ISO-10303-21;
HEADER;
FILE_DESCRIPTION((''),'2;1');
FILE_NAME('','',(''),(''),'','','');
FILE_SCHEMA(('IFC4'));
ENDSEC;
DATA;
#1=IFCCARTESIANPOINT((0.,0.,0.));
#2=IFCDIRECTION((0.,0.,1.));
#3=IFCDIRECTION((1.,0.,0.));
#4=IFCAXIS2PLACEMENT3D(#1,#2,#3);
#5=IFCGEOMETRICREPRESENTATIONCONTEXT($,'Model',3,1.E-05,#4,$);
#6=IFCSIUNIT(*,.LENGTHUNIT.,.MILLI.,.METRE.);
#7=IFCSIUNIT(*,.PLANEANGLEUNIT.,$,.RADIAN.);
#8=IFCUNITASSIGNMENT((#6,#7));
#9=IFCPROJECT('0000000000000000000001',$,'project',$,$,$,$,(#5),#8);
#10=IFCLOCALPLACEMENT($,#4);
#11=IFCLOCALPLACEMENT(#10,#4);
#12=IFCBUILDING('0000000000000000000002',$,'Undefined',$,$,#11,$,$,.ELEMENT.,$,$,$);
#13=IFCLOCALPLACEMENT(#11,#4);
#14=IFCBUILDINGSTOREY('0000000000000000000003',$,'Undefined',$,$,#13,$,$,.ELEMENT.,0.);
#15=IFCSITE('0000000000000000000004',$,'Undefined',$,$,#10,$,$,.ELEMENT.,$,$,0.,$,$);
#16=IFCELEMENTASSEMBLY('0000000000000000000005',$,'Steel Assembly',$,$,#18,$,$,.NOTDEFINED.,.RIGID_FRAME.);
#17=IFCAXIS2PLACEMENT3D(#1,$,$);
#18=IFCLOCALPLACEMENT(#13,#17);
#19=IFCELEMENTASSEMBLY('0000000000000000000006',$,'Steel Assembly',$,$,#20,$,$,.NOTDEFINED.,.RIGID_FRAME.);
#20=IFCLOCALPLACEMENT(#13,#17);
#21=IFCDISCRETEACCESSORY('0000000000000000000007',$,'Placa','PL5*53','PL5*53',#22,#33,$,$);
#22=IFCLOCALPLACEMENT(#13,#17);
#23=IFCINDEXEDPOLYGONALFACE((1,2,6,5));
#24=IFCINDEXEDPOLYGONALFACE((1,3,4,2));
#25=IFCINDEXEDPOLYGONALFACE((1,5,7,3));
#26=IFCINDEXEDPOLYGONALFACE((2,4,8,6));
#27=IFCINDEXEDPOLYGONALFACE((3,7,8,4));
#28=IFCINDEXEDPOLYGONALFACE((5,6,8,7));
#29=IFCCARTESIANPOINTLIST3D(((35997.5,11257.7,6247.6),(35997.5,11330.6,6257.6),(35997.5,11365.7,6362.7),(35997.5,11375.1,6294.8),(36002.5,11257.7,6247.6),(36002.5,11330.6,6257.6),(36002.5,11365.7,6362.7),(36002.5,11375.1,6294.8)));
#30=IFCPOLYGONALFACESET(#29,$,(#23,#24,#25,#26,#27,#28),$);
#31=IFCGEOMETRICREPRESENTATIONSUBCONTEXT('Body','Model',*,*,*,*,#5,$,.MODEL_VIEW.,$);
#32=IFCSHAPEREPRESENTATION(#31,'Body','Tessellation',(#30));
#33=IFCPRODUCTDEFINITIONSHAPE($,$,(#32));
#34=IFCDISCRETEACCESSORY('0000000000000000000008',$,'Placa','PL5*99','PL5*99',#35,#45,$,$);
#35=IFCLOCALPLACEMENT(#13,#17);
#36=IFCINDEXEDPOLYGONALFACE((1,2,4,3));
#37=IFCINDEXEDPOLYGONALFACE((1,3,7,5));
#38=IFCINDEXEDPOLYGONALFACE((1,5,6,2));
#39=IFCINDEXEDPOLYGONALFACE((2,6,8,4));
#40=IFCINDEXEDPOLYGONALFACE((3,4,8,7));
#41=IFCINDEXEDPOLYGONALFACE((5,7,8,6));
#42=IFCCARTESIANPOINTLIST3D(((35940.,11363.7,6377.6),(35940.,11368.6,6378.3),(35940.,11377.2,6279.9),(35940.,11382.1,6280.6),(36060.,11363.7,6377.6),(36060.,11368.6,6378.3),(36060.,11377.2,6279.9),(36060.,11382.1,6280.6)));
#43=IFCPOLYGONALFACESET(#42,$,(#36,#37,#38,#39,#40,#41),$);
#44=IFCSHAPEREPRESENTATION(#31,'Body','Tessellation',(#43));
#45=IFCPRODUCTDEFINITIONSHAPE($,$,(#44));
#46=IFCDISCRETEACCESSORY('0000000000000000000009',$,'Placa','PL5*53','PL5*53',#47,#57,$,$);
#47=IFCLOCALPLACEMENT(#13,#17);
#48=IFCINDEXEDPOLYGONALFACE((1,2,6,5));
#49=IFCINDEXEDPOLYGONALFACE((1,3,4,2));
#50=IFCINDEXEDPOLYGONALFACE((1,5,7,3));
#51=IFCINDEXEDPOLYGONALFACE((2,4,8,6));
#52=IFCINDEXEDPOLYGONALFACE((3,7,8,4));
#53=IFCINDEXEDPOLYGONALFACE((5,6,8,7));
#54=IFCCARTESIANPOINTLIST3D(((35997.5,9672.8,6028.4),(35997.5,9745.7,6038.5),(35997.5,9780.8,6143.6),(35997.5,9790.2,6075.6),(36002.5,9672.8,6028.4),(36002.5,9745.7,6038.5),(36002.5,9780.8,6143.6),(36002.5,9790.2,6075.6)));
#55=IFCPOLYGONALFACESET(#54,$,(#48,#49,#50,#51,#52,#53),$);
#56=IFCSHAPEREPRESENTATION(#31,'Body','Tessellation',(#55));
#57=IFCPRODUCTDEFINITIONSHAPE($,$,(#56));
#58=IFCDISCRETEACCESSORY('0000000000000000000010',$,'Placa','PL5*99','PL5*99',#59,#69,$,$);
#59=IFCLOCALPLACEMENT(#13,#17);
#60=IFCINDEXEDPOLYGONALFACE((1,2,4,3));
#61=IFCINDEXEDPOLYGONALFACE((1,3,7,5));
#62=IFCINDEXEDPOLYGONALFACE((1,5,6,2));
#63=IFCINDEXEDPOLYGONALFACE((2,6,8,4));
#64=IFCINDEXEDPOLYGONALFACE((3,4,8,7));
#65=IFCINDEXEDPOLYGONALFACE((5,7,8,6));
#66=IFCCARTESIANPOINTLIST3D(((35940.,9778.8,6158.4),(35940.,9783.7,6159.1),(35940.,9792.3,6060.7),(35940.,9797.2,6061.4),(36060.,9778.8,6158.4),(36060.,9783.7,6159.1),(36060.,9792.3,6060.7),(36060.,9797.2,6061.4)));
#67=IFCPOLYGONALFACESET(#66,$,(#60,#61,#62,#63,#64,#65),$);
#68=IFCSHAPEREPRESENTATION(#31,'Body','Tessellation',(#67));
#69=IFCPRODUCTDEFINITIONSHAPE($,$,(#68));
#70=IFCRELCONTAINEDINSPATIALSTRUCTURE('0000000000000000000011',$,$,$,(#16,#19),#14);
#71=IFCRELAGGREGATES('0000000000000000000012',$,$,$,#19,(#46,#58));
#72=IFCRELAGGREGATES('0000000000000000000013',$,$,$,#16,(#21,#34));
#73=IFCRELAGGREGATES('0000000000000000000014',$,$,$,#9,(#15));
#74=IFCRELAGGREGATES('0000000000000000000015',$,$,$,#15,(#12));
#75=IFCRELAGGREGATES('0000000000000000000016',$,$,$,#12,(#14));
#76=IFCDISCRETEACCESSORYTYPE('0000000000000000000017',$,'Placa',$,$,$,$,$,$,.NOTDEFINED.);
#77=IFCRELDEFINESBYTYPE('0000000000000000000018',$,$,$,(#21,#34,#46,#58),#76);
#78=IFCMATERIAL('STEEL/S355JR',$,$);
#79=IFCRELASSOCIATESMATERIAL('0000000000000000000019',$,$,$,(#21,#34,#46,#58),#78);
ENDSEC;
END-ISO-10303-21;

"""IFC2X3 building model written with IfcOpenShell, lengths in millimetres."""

from ifc_helpers import new_model, si_unit, frame, origin_with_axes, place, context, subcontext, project, spatial, polyline, outline, extrude, material, type_object, element, aggregate, save


model = new_model("IFC2X3")

# Units and contexts
model_context = context("Model", 3, precision=1e-05, world=origin_with_axes())
body_context = subcontext(model_context, "Body", "Model", "MODEL_VIEW")
ifc_project = project(units=[si_unit("LENGTHUNIT", "METRE", prefix="MILLI"), si_unit("PLANEANGLEUNIT", "RADIAN")], contexts=[model_context])

# Site, building, storey
site_placement = place(None, origin_with_axes())
site = spatial("IfcSite", under=ifc_project, at=site_placement, Name="Undefined", CompositionType="ELEMENT", RefElevation=0.0)
building_placement = place(site_placement, origin_with_axes())
building = spatial("IfcBuilding", under=site, at=building_placement, Name="Undefined", CompositionType="ELEMENT")
storey_placement = place(building_placement, origin_with_axes())
storey = spatial("IfcBuildingStorey", under=building, at=storey_placement, Name="Undefined", CompositionType="ELEMENT", Elevation=0.0)

# Shared definitions
ifc_material_1 = material(Name="STEEL/S355JR")

# Element assemblies
assembly_1_placement = place(storey_placement, origin_with_axes())
assembly_1 = element("IfcElementAssembly", 1, at=assembly_1_placement, inside=storey, Name="Steel Assembly", AssemblyPlace="NOTDEFINED", PredefinedType="RIGID_FRAME")
assembly_2_placement = place(storey_placement, origin_with_axes())
assembly_2 = element("IfcElementAssembly", 2, at=assembly_2_placement, inside=storey, Name="Steel Assembly", AssemblyPlace="NOTDEFINED", PredefinedType="RIGID_FRAME")

# Discrete accessories
discrete_accessory_type_1 = type_object("IfcDiscreteAccessoryType", Name="Placa")
discrete_accessory_1_placement = place(assembly_1_placement, frame((36000.0, 11365.7, 6362.7), z_axis=(1.0, 0.0, 0.0), x_axis=(0.0, -0.684057, -0.729429)))
discrete_accessory_1 = element("IfcDiscreteAccessory", 3, at=discrete_accessory_1_placement, type_object=discrete_accessory_type_1, material=ifc_material_1, Name="Placa", Description="PL5*53", ObjectType="PL5*53", context=body_context, shape_type="SweptSolid", body=[
    extrude(outline(polyline([(0.0, 0.0), (157.9, 0.0), (100.7, 46.3), (43.1, 53.3), (0.0, 0.0)])), frame((0.0, 0.0, -2.5), z_axis=(0.0, 0.0, 1.0), x_axis=(1.0, 0.0, 0.0)), (0.0, 0.0, 1.0), 5.0),
])
discrete_accessory_2_placement = place(assembly_1_placement, frame((35940.0, 11379.7, 6280.3), z_axis=(0.0, 0.990592, 0.136849), x_axis=(0.0, -0.136849, 0.990592)))
discrete_accessory_2 = element("IfcDiscreteAccessory", 4, at=discrete_accessory_2_placement, type_object=discrete_accessory_type_1, material=ifc_material_1, Name="Placa", Description="PL5*99", ObjectType="PL5*99", context=body_context, shape_type="SweptSolid", body=[
    extrude(outline(polyline([(0.0, 0.0), (98.6, 0.0), (98.6, 120.0), (0.0, 120.0), (0.0, 0.0)])), frame((0.0, 0.0, -2.5), z_axis=(0.0, 0.0, 1.0), x_axis=(1.0, 0.0, 0.0)), (0.0, 0.0, 1.0), 5.0),
])
discrete_accessory_3_placement = place(assembly_2_placement, frame((36000.0, 9780.8, 6143.6), z_axis=(1.0, 0.0, 0.0), x_axis=(0.0, -0.684057, -0.729429)))
discrete_accessory_3 = element("IfcDiscreteAccessory", 5, at=discrete_accessory_3_placement, type_object=discrete_accessory_type_1, material=ifc_material_1, Name="Placa", Description="PL5*53", ObjectType="PL5*53", context=body_context, shape_type="SweptSolid", body=[
    extrude(outline(polyline([(0.0, 0.0), (157.9, 0.0), (100.7, 46.3), (43.1, 53.3), (0.0, 0.0)])), frame((0.0, 0.0, -2.5), z_axis=(0.0, 0.0, 1.0), x_axis=(1.0, 0.0, 0.0)), (0.0, 0.0, 1.0), 5.0),
])
discrete_accessory_4_placement = place(assembly_2_placement, frame((35940.0, 9794.7, 6061.1), z_axis=(0.0, 0.990592, 0.136849), x_axis=(0.0, -0.136849, 0.990592)))
discrete_accessory_4 = element("IfcDiscreteAccessory", 6, at=discrete_accessory_4_placement, type_object=discrete_accessory_type_1, material=ifc_material_1, Name="Placa", Description="PL5*99", ObjectType="PL5*99", context=body_context, shape_type="SweptSolid", body=[
    extrude(outline(polyline([(0.0, 0.0), (98.6, 0.0), (98.6, 120.0), (0.0, 120.0), (0.0, 0.0)])), frame((0.0, 0.0, -2.5), z_axis=(0.0, 0.0, 1.0), x_axis=(1.0, 0.0, 0.0)), (0.0, 0.0, 1.0), 5.0),
])

aggregate(assembly_2, [discrete_accessory_3, discrete_accessory_4])
aggregate(assembly_1, [discrete_accessory_1, discrete_accessory_2])

save(model, "model.ifc")
